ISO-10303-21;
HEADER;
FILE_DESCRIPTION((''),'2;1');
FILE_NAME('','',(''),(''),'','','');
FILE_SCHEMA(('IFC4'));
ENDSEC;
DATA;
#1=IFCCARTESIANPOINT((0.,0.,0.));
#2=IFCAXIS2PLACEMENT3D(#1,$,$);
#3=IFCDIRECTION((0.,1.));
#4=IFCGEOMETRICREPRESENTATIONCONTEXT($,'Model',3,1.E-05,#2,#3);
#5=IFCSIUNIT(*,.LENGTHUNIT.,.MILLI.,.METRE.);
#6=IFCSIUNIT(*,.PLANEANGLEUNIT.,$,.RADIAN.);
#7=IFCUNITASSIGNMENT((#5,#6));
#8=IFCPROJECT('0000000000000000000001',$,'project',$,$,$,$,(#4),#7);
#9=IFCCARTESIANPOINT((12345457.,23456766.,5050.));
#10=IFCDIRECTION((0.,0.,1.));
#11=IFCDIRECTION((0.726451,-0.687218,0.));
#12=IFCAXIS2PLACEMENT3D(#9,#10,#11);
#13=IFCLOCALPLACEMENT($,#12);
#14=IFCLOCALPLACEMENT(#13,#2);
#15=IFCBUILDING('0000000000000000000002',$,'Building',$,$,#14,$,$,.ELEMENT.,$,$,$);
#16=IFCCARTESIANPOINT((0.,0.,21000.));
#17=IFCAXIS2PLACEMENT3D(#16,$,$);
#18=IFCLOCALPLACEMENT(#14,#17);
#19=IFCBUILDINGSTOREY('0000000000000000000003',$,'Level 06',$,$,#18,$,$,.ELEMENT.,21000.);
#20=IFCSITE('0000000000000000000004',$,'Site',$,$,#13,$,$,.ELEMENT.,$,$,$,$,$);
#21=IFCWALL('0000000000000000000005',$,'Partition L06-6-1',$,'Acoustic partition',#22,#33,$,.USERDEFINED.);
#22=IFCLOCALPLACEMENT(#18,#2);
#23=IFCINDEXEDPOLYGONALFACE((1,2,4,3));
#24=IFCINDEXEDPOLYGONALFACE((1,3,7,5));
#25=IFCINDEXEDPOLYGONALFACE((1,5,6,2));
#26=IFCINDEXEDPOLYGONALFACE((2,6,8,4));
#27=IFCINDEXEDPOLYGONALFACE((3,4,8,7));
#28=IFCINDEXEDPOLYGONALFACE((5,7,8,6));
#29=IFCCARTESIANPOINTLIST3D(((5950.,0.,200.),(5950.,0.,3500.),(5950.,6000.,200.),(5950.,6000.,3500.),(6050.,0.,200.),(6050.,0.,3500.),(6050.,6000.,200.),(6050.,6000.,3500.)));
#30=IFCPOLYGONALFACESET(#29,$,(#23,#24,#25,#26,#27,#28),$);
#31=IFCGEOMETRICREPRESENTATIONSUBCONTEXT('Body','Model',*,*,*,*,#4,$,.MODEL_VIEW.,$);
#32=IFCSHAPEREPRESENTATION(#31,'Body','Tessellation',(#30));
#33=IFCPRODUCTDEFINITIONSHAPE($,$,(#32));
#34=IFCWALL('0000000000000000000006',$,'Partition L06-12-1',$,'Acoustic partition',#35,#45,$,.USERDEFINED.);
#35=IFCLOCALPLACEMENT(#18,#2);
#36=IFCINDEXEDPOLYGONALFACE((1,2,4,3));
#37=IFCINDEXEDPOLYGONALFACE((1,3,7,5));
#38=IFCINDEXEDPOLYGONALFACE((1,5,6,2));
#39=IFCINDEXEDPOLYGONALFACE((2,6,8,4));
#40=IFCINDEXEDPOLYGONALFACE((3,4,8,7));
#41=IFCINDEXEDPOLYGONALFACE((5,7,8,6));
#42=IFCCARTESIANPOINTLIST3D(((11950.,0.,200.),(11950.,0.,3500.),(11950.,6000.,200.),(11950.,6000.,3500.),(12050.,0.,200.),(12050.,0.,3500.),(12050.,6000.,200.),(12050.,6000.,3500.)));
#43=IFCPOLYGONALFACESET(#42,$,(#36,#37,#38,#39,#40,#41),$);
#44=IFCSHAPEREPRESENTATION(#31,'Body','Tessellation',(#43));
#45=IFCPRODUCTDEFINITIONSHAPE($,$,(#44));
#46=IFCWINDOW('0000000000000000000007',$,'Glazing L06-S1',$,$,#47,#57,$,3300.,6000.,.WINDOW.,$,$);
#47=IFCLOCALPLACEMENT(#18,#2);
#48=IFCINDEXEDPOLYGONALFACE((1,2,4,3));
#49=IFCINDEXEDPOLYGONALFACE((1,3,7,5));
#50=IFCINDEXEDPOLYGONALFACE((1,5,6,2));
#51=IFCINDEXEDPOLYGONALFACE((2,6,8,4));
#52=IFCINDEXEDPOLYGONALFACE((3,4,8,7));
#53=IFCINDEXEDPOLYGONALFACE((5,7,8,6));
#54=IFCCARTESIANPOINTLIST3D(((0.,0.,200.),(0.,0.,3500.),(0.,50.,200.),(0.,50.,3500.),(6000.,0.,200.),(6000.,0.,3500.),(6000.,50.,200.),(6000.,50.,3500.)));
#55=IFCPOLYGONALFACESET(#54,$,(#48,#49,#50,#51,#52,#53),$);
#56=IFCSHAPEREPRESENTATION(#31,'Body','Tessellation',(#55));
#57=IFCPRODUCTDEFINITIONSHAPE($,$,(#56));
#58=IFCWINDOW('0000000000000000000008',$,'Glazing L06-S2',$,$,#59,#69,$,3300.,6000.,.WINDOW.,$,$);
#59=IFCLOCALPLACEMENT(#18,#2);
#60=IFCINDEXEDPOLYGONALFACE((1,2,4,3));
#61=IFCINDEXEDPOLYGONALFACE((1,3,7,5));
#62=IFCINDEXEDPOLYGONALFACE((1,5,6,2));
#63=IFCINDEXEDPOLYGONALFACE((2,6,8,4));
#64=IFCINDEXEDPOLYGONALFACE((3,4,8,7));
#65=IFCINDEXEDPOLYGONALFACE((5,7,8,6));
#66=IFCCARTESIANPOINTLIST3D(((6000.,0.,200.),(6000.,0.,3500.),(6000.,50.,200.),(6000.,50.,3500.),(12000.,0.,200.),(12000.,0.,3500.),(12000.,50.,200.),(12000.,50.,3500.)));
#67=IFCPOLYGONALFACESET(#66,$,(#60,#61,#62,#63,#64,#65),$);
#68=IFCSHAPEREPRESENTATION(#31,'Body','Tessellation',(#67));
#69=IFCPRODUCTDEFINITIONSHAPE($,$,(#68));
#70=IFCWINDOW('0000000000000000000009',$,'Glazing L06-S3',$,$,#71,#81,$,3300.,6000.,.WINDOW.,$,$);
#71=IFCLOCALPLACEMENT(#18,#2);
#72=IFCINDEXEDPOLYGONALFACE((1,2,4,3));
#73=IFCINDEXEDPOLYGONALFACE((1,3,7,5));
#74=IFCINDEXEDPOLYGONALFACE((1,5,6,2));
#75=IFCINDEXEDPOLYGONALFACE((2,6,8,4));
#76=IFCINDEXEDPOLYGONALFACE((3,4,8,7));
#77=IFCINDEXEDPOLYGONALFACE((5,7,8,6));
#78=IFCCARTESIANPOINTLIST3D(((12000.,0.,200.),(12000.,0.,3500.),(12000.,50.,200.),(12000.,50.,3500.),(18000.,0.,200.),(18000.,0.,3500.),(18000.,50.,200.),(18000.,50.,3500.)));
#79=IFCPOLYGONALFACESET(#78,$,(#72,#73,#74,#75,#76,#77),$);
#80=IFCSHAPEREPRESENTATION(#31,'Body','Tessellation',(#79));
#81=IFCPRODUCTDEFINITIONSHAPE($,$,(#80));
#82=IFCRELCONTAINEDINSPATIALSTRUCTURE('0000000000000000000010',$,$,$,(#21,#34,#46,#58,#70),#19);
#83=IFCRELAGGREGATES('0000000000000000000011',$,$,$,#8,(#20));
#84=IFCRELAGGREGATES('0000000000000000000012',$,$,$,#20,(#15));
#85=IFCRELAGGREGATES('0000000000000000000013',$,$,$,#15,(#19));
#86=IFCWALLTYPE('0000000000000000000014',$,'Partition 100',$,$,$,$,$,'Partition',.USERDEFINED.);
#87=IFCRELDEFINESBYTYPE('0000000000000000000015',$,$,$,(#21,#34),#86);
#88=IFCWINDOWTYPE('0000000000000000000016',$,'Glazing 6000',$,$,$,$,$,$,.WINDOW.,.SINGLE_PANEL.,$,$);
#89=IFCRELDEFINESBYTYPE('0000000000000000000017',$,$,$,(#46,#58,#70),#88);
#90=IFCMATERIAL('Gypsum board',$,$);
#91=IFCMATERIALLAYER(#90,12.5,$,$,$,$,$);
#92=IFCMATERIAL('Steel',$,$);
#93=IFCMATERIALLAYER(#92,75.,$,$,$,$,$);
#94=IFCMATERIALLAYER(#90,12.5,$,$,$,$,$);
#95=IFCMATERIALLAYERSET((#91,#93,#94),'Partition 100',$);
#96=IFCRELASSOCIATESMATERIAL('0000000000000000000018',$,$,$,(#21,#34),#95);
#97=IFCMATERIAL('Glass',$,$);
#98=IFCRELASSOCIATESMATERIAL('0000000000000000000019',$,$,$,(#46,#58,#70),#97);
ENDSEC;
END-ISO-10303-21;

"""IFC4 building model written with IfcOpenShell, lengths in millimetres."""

from ifc_helpers import new_model, si_unit, direction, frame, origin, place, context, subcontext, project, spatial, rectangle, extrude, material, layer, layer_set, layer_usage, type_object, element, save


model = new_model("IFC4")

# Units and contexts
model_context = context("Model", 3, precision=1e-05, world=origin(), true_north=direction((0.0, 1.0)))
body_context = subcontext(model_context, "Body", "Model", "MODEL_VIEW")
ifc_project = project(units=[si_unit("LENGTHUNIT", "METRE", prefix="MILLI"), si_unit("PLANEANGLEUNIT", "RADIAN")], contexts=[model_context])

# Site, building, storey
site_placement = place(None, frame((12345457.0, 23456766.0, 5050.0), z_axis=(0.0, 0.0, 1.0), x_axis=(0.726451, -0.687218, 0.0)))
site = spatial("IfcSite", under=ifc_project, at=site_placement, Name="Site", CompositionType="ELEMENT")
building_placement = place(site_placement, origin())
building = spatial("IfcBuilding", under=site, at=building_placement, Name="Building", CompositionType="ELEMENT")
storey_placement = place(building_placement, frame((0.0, 0.0, 21000.0)))
storey = spatial("IfcBuildingStorey", under=building, at=storey_placement, Name="Level 06", CompositionType="ELEMENT", Elevation=21000.0)

# Shared definitions
ifc_material_1 = material(Name="Steel")

# Walls
ifc_material_2 = material(Name="Gypsum board")
ifc_layer_1 = layer(ifc_material_2, 12.5)
ifc_layer_2 = layer(ifc_material_1, 75.0)
ifc_layer_3 = layer(ifc_material_2, 12.5)
ifc_layer_set_1 = layer_set([ifc_layer_1, ifc_layer_2, ifc_layer_3], Name="Partition 100")
ifc_layer_usage_1 = layer_usage(ifc_layer_set_1, "AXIS2", "POSITIVE", 0.0)
wall_type_1 = type_object("IfcWallType", Name="Partition 100", ElementType="Partition", PredefinedType="USERDEFINED")
for number, where, name in (
    (1, (5950.0, 0.0, 200.0), "Partition L06-6-1"),
    (2, (11950.0, 0.0, 200.0), "Partition L06-12-1"),
):
    element("IfcWall", number, at=place(storey_placement, frame(where)), inside=storey, type_object=wall_type_1, material=ifc_layer_usage_1, Name=name, ObjectType="Acoustic partition", PredefinedType="USERDEFINED", context=body_context, shape_type="SweptSolid", body=[
        extrude(rectangle(XDim=100.0, YDim=6000.0), frame((50.0, 3000.0, 0.0)), (0.0, 0.0, 1.0), 3300.0),
    ])

# Windows
ifc_material_3 = material(Name="Glass")
window_type = type_object("IfcWindowType", Name="Glazing 6000", PartitioningType="SINGLE_PANEL", PredefinedType="WINDOW")
for number, where, name in (
    (3, (0.0, 0.0, 200.0), "Glazing L06-S1"),
    (4, (6000.0, 0.0, 200.0), "Glazing L06-S2"),
    (5, (12000.0, 0.0, 200.0), "Glazing L06-S3"),
):
    element("IfcWindow", number, at=place(storey_placement, frame(where)), inside=storey, type_object=window_type, material=ifc_material_3, Name=name, OverallHeight=3300.0, OverallWidth=6000.0, PredefinedType="WINDOW", context=body_context, shape_type="SweptSolid", body=[
        extrude(rectangle(XDim=6000.0, YDim=50.0), frame((3000.0, 25.0, 0.0)), (0.0, 0.0, 1.0), 3300.0),
    ])

save(model, "model.ifc")
